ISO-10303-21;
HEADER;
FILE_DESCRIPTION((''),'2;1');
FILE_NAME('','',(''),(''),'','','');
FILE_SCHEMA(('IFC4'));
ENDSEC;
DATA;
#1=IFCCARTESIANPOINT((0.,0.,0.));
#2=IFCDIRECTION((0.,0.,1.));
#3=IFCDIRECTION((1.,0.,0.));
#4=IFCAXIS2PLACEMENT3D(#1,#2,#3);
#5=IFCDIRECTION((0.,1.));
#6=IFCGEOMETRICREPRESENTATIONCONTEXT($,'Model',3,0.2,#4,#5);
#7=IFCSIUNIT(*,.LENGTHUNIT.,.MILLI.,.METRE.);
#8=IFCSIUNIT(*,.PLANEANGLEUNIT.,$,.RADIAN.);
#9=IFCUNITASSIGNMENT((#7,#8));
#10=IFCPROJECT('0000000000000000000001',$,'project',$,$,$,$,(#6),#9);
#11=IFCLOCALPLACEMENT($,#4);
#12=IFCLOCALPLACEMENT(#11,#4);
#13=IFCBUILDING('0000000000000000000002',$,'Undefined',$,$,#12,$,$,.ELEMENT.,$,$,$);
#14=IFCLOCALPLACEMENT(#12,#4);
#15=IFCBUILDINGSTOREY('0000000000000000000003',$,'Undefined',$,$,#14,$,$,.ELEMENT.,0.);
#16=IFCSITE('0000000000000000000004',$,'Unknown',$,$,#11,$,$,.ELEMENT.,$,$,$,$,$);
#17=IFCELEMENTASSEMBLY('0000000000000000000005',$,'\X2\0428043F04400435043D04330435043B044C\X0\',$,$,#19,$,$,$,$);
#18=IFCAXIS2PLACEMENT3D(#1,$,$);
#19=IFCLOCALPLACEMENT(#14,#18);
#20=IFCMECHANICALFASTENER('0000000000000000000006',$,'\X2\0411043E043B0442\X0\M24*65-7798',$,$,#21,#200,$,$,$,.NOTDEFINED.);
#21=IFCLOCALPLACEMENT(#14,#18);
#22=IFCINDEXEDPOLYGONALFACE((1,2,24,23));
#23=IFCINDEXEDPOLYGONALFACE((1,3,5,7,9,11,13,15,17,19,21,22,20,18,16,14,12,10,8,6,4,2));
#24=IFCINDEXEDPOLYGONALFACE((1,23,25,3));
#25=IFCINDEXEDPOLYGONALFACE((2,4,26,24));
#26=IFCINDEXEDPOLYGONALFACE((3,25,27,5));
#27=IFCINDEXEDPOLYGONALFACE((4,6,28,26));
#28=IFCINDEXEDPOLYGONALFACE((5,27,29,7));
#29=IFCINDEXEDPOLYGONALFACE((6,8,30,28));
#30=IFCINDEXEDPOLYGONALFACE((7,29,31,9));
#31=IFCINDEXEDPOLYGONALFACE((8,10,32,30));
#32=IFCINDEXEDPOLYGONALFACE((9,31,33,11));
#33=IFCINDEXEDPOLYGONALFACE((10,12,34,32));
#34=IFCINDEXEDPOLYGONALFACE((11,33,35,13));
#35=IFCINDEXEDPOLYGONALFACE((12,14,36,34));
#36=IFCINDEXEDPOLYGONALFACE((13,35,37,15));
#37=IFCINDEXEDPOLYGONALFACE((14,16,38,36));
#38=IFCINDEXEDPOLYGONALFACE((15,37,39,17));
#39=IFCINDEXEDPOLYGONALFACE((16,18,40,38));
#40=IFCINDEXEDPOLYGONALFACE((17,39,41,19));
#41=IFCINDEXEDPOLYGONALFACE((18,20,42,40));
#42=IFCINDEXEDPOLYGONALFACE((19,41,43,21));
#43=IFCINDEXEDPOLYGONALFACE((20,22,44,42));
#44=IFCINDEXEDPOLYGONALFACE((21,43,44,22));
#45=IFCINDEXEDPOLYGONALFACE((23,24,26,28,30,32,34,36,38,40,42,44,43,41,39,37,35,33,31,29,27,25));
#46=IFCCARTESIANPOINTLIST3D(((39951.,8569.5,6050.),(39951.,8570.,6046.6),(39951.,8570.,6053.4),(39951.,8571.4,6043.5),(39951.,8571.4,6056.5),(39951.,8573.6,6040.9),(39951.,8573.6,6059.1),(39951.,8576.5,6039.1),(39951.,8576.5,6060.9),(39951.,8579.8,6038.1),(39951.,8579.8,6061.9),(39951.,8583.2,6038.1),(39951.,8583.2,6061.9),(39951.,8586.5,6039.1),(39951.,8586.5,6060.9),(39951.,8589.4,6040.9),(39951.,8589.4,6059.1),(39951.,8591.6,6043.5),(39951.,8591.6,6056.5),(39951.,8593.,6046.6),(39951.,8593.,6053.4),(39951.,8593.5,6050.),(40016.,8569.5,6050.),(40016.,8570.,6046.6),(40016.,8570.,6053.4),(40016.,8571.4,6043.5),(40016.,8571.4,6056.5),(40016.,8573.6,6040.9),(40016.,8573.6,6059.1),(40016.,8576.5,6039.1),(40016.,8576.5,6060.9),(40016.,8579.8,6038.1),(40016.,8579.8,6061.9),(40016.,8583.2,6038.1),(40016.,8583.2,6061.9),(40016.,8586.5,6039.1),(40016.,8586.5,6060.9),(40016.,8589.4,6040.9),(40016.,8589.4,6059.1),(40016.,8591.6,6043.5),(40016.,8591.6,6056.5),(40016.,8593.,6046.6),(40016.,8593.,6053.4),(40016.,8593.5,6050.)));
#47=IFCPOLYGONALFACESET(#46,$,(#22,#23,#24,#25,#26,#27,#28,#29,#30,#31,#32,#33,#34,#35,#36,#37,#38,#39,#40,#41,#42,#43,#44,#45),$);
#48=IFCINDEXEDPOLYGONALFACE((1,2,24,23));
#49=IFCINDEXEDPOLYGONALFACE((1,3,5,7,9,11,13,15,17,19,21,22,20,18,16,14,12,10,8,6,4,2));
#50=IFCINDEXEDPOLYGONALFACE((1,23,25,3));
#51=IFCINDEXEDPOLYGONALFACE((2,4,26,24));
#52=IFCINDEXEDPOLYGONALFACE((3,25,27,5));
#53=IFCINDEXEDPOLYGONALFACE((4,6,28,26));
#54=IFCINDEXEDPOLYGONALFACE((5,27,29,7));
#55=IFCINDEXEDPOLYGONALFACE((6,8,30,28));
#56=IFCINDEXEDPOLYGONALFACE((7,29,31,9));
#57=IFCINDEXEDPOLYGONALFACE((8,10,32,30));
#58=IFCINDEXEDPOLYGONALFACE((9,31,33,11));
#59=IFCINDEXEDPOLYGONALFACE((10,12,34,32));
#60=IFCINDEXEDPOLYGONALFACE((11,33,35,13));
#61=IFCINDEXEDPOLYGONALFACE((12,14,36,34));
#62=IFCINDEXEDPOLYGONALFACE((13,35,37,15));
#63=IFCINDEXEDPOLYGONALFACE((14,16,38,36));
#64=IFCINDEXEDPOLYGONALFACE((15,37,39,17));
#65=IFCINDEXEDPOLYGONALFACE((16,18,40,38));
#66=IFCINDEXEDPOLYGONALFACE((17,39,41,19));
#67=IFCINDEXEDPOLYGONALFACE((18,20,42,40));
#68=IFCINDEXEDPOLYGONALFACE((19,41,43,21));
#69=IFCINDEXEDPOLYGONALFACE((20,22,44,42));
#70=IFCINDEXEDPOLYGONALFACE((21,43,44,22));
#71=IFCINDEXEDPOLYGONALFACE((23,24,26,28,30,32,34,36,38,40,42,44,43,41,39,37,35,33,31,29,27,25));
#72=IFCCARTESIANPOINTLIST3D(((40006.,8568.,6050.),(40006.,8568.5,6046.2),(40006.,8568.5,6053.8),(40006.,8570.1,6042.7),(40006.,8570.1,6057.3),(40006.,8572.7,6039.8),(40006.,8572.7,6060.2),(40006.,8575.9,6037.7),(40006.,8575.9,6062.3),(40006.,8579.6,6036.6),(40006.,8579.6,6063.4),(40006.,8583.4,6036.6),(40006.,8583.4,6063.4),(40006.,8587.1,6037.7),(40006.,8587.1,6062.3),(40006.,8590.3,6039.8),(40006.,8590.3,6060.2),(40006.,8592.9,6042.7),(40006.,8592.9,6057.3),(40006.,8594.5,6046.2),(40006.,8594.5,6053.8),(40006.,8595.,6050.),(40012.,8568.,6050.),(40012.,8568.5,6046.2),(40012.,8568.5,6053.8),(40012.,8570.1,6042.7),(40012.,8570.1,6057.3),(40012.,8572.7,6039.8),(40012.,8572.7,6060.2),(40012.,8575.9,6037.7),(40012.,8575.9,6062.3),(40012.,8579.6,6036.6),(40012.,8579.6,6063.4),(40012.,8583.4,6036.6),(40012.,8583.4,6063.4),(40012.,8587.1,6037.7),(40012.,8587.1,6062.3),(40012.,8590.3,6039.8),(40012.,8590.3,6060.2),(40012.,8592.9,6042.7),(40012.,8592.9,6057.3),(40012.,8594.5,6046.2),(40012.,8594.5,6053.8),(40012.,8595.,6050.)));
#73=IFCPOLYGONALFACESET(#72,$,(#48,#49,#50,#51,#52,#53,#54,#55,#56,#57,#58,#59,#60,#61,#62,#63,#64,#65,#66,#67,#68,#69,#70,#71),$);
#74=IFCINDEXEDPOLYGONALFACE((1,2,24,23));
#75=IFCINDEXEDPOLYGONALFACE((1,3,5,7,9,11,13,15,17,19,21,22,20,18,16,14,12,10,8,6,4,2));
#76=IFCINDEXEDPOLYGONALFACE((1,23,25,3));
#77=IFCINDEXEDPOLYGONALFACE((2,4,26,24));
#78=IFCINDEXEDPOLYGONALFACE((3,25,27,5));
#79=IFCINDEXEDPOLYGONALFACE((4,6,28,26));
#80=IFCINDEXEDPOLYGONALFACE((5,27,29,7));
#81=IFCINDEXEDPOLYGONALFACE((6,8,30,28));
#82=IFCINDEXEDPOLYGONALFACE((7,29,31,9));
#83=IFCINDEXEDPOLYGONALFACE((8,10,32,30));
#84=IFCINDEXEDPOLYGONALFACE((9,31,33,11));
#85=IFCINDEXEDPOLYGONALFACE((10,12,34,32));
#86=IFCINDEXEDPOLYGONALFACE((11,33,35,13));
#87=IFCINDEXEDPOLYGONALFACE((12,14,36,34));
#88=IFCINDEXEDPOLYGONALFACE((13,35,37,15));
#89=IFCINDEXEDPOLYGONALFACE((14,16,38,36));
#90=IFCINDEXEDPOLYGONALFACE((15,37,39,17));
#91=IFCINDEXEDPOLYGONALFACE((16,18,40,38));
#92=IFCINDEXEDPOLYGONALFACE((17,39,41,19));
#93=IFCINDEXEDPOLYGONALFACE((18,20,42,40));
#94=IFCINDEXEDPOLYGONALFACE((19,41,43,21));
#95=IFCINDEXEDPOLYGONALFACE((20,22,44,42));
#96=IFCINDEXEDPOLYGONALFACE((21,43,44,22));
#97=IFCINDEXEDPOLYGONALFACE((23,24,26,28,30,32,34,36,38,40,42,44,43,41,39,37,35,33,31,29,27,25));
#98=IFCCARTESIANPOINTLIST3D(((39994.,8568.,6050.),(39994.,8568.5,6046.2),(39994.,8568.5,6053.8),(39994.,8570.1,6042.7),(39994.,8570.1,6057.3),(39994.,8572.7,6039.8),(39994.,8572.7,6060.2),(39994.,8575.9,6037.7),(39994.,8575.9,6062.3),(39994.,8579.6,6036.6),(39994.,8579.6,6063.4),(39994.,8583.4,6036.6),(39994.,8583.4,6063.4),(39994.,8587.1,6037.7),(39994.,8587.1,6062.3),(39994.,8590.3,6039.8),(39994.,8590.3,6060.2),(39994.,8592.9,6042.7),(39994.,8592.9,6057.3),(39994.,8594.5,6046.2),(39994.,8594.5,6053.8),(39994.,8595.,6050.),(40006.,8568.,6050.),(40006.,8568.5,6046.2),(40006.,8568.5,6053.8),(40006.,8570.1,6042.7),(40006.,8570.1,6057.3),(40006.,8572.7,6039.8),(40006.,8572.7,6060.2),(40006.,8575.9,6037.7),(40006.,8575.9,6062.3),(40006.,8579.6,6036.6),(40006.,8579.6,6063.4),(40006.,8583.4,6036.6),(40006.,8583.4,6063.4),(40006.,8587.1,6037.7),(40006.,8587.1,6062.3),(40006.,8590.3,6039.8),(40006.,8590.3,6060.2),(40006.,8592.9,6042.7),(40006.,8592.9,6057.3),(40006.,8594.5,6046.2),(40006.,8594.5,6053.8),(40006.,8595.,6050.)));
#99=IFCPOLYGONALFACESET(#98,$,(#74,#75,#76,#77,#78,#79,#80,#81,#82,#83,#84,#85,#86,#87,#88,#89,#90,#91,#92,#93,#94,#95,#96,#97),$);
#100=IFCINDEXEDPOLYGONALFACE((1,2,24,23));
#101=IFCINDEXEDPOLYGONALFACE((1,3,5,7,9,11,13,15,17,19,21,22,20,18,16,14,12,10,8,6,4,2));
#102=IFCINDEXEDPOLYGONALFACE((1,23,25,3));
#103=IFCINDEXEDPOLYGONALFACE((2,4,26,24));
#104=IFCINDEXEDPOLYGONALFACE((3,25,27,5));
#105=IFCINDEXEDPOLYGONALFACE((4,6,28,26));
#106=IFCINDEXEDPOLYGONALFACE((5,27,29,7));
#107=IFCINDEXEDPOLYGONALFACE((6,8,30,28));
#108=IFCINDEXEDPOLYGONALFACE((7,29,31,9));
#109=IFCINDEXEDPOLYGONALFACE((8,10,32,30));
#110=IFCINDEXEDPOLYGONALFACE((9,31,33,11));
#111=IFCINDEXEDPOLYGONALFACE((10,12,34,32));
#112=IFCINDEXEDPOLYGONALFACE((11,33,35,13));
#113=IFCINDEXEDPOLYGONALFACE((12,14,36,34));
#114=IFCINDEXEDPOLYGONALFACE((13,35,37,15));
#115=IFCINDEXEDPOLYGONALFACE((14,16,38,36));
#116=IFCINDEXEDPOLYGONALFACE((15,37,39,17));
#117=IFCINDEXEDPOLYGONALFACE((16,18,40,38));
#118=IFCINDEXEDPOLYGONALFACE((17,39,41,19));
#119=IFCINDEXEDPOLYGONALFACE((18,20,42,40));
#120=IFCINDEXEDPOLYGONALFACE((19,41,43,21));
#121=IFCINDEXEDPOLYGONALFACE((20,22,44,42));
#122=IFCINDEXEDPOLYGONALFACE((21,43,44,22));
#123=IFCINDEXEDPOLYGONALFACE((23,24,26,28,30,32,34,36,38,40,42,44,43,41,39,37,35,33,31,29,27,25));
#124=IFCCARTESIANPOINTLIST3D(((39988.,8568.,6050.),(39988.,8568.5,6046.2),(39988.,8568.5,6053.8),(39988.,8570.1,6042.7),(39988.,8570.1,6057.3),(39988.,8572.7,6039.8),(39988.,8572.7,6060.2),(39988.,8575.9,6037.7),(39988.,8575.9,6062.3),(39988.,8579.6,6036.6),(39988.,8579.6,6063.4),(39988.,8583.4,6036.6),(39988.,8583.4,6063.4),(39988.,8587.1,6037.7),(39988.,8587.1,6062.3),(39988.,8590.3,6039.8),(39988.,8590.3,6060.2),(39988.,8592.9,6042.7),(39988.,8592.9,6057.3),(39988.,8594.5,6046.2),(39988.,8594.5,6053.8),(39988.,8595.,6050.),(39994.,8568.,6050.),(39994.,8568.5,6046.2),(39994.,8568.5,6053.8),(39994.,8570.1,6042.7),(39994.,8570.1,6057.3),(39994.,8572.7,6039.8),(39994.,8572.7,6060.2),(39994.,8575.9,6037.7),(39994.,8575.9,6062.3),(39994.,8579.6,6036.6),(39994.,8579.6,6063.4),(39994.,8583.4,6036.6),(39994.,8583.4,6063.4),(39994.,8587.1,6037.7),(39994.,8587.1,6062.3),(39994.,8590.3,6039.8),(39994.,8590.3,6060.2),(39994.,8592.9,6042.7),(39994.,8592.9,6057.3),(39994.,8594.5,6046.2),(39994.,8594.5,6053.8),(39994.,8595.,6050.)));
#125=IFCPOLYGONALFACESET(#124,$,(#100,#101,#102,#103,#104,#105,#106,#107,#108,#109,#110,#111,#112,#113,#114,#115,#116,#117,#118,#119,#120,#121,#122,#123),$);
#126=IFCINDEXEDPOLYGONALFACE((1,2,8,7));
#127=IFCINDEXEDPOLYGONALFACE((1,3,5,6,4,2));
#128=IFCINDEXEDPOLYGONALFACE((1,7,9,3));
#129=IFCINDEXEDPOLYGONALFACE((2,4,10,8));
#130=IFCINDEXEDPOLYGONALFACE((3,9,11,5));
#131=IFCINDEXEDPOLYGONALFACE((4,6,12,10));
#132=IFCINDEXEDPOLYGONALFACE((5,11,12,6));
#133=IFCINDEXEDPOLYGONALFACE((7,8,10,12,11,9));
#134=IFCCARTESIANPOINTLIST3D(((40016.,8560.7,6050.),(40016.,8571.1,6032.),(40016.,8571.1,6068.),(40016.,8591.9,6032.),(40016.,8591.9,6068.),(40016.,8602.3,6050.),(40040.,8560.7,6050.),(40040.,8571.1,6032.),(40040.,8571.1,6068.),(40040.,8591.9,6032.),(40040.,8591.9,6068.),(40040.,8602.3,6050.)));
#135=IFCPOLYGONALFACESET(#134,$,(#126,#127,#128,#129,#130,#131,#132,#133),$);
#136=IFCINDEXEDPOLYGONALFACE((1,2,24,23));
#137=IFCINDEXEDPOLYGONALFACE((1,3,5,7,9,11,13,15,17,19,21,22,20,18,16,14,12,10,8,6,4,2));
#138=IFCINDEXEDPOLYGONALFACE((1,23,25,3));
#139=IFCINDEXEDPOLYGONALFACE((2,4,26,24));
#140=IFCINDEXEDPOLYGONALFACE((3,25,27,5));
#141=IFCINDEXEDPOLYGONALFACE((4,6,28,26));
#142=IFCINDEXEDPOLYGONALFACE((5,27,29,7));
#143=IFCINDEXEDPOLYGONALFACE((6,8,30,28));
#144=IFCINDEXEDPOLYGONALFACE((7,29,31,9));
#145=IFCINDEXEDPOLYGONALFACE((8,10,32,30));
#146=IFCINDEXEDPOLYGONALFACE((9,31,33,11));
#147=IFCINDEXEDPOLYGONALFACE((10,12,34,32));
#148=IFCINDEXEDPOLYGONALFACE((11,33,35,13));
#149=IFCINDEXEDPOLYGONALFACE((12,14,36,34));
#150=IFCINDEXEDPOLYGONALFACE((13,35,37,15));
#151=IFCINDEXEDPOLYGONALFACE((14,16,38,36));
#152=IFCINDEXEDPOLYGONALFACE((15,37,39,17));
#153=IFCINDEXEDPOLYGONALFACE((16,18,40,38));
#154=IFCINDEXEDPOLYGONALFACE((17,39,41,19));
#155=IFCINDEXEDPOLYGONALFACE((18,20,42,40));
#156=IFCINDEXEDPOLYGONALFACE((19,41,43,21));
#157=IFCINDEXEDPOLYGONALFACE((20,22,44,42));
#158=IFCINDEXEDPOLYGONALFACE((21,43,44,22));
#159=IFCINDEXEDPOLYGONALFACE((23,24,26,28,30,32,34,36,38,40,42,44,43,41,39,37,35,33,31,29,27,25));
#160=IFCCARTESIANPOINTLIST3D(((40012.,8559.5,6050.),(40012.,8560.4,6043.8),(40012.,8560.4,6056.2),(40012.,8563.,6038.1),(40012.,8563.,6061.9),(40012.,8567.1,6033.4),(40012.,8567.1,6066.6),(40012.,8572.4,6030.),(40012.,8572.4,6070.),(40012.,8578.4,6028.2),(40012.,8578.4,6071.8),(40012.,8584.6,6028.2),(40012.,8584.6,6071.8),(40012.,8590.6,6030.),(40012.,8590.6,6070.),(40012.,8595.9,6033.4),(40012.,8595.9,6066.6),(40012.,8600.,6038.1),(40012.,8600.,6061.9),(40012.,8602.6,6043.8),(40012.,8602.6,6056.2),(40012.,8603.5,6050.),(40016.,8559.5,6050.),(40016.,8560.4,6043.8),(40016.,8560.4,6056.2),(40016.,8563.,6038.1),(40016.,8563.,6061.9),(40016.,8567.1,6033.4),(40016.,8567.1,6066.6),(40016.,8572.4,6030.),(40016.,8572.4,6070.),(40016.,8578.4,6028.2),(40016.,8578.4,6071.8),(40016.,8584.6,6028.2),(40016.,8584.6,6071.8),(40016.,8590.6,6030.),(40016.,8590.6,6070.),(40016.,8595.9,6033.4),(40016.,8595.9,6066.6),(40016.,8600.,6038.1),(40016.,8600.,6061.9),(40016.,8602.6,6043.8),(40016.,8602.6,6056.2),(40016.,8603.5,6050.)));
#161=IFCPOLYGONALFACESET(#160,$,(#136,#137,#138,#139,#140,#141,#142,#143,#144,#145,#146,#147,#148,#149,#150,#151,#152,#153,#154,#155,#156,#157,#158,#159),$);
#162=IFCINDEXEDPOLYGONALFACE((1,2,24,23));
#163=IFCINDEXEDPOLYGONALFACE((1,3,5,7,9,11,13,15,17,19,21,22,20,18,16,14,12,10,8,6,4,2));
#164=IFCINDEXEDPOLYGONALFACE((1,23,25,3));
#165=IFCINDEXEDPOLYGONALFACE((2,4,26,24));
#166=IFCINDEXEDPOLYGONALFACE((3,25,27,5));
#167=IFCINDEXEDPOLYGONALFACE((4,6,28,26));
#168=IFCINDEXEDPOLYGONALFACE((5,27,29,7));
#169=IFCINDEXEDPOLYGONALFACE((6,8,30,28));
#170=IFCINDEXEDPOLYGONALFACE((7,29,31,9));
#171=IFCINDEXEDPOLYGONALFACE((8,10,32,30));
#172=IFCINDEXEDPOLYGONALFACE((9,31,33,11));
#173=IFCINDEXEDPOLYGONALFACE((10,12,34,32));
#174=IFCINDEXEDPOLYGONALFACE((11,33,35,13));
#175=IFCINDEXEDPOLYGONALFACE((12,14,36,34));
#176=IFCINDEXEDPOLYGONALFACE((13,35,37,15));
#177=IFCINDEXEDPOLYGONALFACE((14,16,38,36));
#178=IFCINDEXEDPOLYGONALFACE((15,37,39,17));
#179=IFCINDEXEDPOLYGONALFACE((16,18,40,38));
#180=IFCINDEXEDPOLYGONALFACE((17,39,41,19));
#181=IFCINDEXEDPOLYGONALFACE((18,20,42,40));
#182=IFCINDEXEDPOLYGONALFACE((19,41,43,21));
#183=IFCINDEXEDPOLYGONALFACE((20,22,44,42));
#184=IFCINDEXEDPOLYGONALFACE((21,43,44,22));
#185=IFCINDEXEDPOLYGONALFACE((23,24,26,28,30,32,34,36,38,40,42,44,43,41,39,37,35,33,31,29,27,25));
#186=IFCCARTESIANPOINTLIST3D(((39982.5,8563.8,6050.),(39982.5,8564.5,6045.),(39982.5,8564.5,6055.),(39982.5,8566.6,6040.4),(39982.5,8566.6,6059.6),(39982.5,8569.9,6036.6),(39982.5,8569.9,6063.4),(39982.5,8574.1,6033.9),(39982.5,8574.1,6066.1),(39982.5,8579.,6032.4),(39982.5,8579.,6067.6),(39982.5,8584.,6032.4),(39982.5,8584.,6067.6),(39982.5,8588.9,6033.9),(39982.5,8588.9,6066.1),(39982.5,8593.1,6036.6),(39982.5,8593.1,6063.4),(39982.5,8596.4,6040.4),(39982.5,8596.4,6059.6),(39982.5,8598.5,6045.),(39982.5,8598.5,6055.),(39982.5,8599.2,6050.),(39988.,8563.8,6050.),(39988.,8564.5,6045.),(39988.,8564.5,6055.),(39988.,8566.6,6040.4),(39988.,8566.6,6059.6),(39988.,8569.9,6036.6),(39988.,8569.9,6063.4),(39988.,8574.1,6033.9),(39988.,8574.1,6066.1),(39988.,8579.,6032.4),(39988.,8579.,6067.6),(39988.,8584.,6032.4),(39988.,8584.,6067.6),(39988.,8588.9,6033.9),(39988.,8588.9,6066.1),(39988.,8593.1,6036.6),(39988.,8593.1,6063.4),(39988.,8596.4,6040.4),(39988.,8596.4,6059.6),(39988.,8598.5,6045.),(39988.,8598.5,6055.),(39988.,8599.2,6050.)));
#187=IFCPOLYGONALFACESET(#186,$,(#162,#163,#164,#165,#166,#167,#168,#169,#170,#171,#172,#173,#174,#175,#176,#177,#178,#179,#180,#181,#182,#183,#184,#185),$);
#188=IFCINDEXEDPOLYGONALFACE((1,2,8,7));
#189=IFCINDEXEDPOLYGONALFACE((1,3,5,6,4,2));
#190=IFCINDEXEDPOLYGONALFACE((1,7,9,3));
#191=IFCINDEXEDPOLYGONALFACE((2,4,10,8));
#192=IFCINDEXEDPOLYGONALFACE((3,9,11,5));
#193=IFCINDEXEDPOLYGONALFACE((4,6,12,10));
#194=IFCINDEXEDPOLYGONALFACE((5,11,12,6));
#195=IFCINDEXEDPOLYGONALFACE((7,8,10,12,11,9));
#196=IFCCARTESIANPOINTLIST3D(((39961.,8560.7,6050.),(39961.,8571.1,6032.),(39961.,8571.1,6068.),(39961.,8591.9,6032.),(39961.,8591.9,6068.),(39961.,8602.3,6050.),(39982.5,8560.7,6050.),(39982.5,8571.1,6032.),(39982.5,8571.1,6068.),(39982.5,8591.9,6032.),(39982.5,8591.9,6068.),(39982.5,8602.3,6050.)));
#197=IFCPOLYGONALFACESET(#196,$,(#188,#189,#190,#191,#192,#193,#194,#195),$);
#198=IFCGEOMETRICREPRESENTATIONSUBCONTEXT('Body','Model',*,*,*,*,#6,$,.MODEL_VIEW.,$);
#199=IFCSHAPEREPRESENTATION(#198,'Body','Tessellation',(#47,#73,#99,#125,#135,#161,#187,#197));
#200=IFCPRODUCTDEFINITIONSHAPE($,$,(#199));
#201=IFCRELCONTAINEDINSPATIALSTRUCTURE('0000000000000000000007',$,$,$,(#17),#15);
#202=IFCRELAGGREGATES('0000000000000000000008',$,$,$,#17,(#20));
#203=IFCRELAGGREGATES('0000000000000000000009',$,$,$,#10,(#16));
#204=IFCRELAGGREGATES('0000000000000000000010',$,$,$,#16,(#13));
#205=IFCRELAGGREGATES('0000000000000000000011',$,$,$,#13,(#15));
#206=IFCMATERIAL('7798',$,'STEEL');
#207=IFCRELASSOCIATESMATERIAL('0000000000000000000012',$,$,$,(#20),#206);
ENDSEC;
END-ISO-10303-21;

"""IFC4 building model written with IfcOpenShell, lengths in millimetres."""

from ifc_helpers import new_model, si_unit, direction, frame, origin_with_axes, place, context, subcontext, project, spatial, line, arc, indexed_curve, outline, extrude, source, transform, mapped, material, element, aggregate, save


model = new_model("IFC4")

# Units and contexts
model_context = context("Model", 3, precision=0.2, world=origin_with_axes(), true_north=direction((0.0, 1.0)))
body_context = subcontext(model_context, "Body", "Model", "MODEL_VIEW")
ifc_project = project(units=[si_unit("LENGTHUNIT", "METRE", prefix="MILLI"), si_unit("PLANEANGLEUNIT", "RADIAN")], contexts=[model_context])

# Site, building, storey
site_placement = place(None, origin_with_axes())
site = spatial("IfcSite", under=ifc_project, at=site_placement, Name="Unknown", CompositionType="ELEMENT")
building_placement = place(site_placement, origin_with_axes())
building = spatial("IfcBuilding", under=site, at=building_placement, Name="Undefined", CompositionType="ELEMENT")
storey_placement = place(building_placement, origin_with_axes())
storey = spatial("IfcBuildingStorey", under=building, at=storey_placement, Name="Undefined", CompositionType="ELEMENT", Elevation=0.0)

# Shared definitions
ifc_material_1 = material(Name="7798", Category="STEEL")

# Element assembly, mechanical fastener
assembly_1_placement = place(storey_placement, frame((39949.0, 5673.0, 6045.0), z_axis=(0.0, 0.0, 1.0), x_axis=(0.0, 1.0, 0.0)))
assembly_1 = element("IfcElementAssembly", 1, at=assembly_1_placement, inside=storey, Name="Шпренгель")
shared_shape_1 = source(origin_with_axes(), body_context, "Body", "SweptSolid", [
    extrude(outline(indexed_curve([(12.0, 0.0), (0.0, 12.0), (-12.0, 0.0), (0.0, -12.0)], segments=[arc(1, 2, 3), arc(3, 4, 1)])), frame((0.0, 0.0, 16.0), z_axis=(0.0, 0.0, -1.0), x_axis=(0.0, 1.0, 0.0)), (0.0, 0.0, 1.0), 65.0),
    extrude(outline(indexed_curve([(13.5, 0.0), (0.0, 13.5), (-13.5, 0.0), (0.0, -13.5)], segments=[arc(1, 2, 3), arc(3, 4, 1)])), frame((0.0, 0.0, 12.0), z_axis=(0.0, 0.0, -1.0), x_axis=(0.0, 1.0, 0.0)), (0.0, 0.0, 1.0), 6.0),
    extrude(outline(indexed_curve([(13.5, 0.0), (0.0, 13.5), (-13.5, 0.0), (0.0, -13.5)], segments=[arc(1, 2, 3), arc(3, 4, 1)])), frame((0.0, 0.0, 6.0), z_axis=(0.0, 0.0, -1.0), x_axis=(0.0, 1.0, 0.0)), (0.0, 0.0, 1.0), 12.0),
    extrude(outline(indexed_curve([(13.5, 0.0), (0.0, 13.5), (-13.5, 0.0), (0.0, -13.5)], segments=[arc(1, 2, 3), arc(3, 4, 1)])), frame((0.0, 0.0, -6.0), z_axis=(0.0, 0.0, -1.0), x_axis=(0.0, 1.0, 0.0)), (0.0, 0.0, 1.0), 6.0),
    extrude(outline(indexed_curve([(20.8, 0.0), (10.4, 18.0), (-10.4, 18.0), (-20.8, 0.0), (-10.4, -18.0), (10.4, -18.0)], segments=[line(1, 2, 3, 4, 5, 6, 1)])), frame((0.0, 0.0, 40.0), z_axis=(0.0, 0.0, -1.0), x_axis=(0.0, 1.0, 0.0)), (0.0, 0.0, 1.0), 24.0),
    extrude(outline(indexed_curve([(22.0, 0.0), (0.0, 22.0), (-22.0, 0.0), (0.0, -22.0)], segments=[arc(1, 2, 3), arc(3, 4, 1)])), frame((0.0, 0.0, 16.0), z_axis=(0.0, 0.0, -1.0), x_axis=(0.0, 1.0, 0.0)), (0.0, 0.0, 1.0), 4.0),
    extrude(outline(indexed_curve([(17.8, 0.0), (0.0, 17.8), (-17.8, 0.0), (0.0, -17.8)], segments=[arc(1, 2, 3), arc(3, 4, 1)])), frame((0.0, 0.0, -12.0), z_axis=(0.0, 0.0, -1.0), x_axis=(0.0, 1.0, 0.0)), (0.0, 0.0, 1.0), 5.5),
    extrude(outline(indexed_curve([(20.8, 0.0), (10.4, 18.0), (-10.4, 18.0), (-20.8, 0.0), (-10.4, -18.0), (10.4, -18.0)], segments=[line(1, 2, 3, 4, 5, 6, 1)])), frame((0.0, 0.0, -17.5), z_axis=(0.0, 0.0, -1.0), x_axis=(0.0, 1.0, 0.0)), (0.0, 0.0, 1.0), 21.5),
])
mechanical_fastener_1_placement = place(assembly_1_placement, frame((2908.5, -51.0, 5.0), z_axis=(0.0, -1.0, 0.0), x_axis=(0.0, 0.0, 1.0)))
mechanical_fastener_1 = element("IfcMechanicalFastener", 2, at=mechanical_fastener_1_placement, material=ifc_material_1, Name="БолтM24*65-7798", PredefinedType="NOTDEFINED", context=body_context, shape_type="MappedRepresentation", body=[
    mapped(shared_shape_1, transform((0.0, 0.0, 0.0))),
])
aggregate(assembly_1, [mechanical_fastener_1])

save(model, "model.ifc")
